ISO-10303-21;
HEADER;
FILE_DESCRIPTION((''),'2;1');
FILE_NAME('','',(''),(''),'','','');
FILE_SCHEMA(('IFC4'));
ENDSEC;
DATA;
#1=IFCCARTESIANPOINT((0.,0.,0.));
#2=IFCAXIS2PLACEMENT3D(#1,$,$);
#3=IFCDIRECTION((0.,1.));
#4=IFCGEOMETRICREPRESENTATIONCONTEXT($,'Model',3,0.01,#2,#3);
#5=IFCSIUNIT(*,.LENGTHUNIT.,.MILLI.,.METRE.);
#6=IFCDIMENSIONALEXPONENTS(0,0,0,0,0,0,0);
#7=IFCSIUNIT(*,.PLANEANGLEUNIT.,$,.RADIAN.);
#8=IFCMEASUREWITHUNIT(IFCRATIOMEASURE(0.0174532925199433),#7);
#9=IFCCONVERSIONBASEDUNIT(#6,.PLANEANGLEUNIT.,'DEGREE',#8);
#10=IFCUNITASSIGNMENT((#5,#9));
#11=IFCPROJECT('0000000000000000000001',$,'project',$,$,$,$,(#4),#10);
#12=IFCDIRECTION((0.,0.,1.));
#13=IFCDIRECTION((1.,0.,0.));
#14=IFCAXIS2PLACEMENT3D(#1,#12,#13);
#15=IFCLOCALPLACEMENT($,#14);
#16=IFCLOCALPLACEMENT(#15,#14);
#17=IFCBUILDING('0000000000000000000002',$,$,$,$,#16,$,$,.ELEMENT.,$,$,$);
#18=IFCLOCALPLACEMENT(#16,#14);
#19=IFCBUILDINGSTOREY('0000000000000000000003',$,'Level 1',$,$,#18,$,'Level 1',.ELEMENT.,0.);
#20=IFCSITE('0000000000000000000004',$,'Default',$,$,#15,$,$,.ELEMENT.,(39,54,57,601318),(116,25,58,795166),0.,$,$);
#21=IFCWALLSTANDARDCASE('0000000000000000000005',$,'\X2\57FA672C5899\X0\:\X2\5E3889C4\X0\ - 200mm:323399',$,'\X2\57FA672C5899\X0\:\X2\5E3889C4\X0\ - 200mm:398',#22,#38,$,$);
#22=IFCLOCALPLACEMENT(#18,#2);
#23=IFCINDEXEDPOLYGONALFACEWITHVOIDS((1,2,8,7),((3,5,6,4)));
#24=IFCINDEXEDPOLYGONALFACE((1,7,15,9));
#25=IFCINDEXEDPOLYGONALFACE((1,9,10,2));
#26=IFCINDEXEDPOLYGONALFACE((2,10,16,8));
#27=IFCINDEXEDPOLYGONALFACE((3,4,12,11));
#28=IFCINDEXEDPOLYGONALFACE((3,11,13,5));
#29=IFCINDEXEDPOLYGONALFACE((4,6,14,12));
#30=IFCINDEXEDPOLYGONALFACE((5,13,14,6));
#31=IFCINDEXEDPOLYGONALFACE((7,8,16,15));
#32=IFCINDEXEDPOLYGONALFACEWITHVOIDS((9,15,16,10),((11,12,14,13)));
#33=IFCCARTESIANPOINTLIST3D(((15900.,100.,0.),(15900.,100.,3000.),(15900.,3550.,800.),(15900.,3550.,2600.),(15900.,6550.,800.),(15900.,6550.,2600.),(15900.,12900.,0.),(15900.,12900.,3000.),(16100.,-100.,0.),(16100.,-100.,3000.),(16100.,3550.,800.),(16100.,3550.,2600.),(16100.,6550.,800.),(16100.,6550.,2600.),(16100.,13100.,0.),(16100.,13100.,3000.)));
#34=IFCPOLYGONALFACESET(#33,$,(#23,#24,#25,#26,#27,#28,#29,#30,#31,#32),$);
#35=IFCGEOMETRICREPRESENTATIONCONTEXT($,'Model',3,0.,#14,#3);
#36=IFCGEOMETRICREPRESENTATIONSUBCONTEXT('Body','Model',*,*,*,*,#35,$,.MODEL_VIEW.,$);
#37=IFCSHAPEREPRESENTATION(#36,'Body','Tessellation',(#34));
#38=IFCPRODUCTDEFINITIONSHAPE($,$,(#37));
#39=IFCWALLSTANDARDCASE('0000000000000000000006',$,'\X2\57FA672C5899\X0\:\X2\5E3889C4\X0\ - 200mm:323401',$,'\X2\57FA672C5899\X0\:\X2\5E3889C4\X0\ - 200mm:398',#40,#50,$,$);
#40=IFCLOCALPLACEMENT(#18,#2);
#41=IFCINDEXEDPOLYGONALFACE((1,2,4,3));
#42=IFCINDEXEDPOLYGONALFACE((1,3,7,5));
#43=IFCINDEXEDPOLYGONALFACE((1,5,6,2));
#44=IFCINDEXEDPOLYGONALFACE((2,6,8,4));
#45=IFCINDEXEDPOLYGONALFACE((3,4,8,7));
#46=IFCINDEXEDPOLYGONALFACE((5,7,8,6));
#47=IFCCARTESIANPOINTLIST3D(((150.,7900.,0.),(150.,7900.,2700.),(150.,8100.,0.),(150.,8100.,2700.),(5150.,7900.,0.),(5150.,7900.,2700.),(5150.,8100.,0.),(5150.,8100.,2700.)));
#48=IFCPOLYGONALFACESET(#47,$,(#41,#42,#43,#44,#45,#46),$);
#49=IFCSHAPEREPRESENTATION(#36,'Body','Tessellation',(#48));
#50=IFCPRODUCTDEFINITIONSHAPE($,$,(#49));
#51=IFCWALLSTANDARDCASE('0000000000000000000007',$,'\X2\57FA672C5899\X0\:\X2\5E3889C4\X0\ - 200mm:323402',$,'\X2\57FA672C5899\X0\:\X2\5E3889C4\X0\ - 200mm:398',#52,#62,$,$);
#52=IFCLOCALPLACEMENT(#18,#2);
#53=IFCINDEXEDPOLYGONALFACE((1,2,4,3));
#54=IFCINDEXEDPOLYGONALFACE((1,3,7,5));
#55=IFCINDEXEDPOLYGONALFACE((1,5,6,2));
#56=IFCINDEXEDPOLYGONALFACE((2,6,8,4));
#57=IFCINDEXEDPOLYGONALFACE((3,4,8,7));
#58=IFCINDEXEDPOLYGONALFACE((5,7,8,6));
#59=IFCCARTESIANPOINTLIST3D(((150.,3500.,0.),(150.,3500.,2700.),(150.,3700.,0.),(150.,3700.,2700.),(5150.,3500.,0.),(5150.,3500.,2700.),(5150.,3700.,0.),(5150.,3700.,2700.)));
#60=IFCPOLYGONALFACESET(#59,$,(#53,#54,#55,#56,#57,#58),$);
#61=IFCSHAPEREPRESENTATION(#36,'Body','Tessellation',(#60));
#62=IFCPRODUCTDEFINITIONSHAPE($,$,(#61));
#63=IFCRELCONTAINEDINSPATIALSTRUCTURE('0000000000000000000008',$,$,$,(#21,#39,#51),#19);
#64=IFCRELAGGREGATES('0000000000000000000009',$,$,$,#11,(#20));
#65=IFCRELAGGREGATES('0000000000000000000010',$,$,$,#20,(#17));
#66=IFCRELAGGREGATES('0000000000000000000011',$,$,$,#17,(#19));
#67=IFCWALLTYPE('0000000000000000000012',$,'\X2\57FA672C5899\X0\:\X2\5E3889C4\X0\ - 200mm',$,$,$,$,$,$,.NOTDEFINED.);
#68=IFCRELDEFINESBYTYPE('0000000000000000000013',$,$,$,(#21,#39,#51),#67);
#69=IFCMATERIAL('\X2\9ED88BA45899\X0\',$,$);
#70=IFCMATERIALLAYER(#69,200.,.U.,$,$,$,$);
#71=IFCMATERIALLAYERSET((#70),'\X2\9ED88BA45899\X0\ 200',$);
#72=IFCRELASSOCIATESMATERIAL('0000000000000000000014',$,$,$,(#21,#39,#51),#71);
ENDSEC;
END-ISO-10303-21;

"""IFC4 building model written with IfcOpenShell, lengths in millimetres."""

from ifc_helpers import new_model, entity, si_unit, converted_unit, direction, frame, origin, origin_with_axes, place, context, subcontext, project, spatial, polyline, outline, extrude, clip, halfspace, material, layer, layer_set, layer_usage, type_object, element, save


model = new_model("IFC4")

# Units and contexts
model_context_1 = context("Model", 3, precision=0.01, world=origin(), true_north=direction((0.0, 1.0)))
model_context_2 = context("Model", 3, precision=0.0, world=origin_with_axes(), true_north=direction((0.0, 1.0)))
body_context = subcontext(model_context_2, "Body", "Model", "MODEL_VIEW")
ifc_project = project(units=[si_unit("LENGTHUNIT", "METRE", prefix="MILLI"), converted_unit("PLANEANGLEUNIT", "DEGREE", entity("IfcRatioMeasure", 0.0174532925199433), si_unit("PLANEANGLEUNIT", "RADIAN"), dimensions=[0, 0, 0, 0, 0, 0, 0])], contexts=[model_context_1])

# Site, building, storey
site_placement = place(None, origin_with_axes())
site = spatial("IfcSite", under=ifc_project, at=site_placement, Name="Default", CompositionType="ELEMENT", RefLatitude=(39, 54, 57, 601318), RefLongitude=(116, 25, 58, 795166), RefElevation=0.0)
building_placement = place(site_placement, origin_with_axes())
building = spatial("IfcBuilding", under=site, at=building_placement, CompositionType="ELEMENT")
storey_placement = place(building_placement, origin_with_axes())
storey = spatial("IfcBuildingStorey", under=building, at=storey_placement, Name="Level 1", LongName="Level 1", CompositionType="ELEMENT", Elevation=0.0)

# Shared definitions
ifc_material_1 = material(Name="默认墙")
ifc_layer_1 = layer(ifc_material_1, 200.0, ventilated="UNKNOWN")
ifc_layer_set_1 = layer_set([ifc_layer_1], Name="默认墙 200")
wall_type = type_object("IfcWallType", Name="基本墙:常规 - 200mm", PredefinedType="NOTDEFINED")

# Wall, opening
ifc_layer_usage_1 = layer_usage(ifc_layer_set_1, "AXIS2", "POSITIVE", -100.0)
wall_1_placement = place(storey_placement, frame((16000.0, 13000.0, 0.0), z_axis=(0.0, 0.0, 1.0), x_axis=(0.0, -1.0, 0.0)))
wall_1 = element("IfcWallStandardCase", 1, at=wall_1_placement, inside=storey, type_object=wall_type, material=ifc_layer_usage_1, Name="基本墙:常规 - 200mm:323399", ObjectType="基本墙:常规 - 200mm:398", context=body_context, shape_type="SweptSolid", body=[
    extrude(outline(polyline([(100.0, -100.0), (12900.0, -100.0), (13100.0, 100.0), (-100.0, 100.0), (100.0, -100.0)])), origin_with_axes(), (0.0, 0.0, 1.0), 3000.0),
])
opening_1_placement = place(wall_1_placement, frame((7950.0, 0.0, 800.0), z_axis=(0.0, 0.0, 1.0), x_axis=(1.0, 0.0, 0.0)))
element("IfcOpeningElement", 2, at=opening_1_placement, cuts=wall_1, context=body_context, shape_type="SweptSolid", body=[
    extrude(outline(polyline([(-1500.0, 0.0), (-1500.0, -1800.0), (1500.0, -1800.0), (1500.0, 0.0), (-1500.0, 0.0)])), frame((0.0, -100.0, 0.0), z_axis=(0.0, 1.0, 0.0), x_axis=(1.0, 0.0, 0.0)), (0.0, 0.0, 1.0), 200.0),
])

# Walls
ifc_layer_usage_2 = layer_usage(ifc_layer_set_1, "AXIS2", "POSITIVE", -100.0)
wall_2_placement = place(storey_placement, frame((150.0, 8000.0, 0.0), z_axis=(0.0, 0.0, 1.0), x_axis=(1.0, 0.0, 0.0)))
element("IfcWallStandardCase", 3, at=wall_2_placement, inside=storey, type_object=wall_type, material=ifc_layer_usage_2, Name="基本墙:常规 - 200mm:323401", ObjectType="基本墙:常规 - 200mm:398", context=body_context, shape_type="Clipping", body=[
    clip(extrude(outline(polyline([(0.0, -100.0), (5000.0, -100.0), (5000.0, 100.0), (0.0, 100.0), (0.0, -100.0)])), origin_with_axes(), (0.0, 0.0, 1.0), 2700.0), halfspace(frame((0.0, 0.0, 2700.0), z_axis=(0.0, 0.0, -1.0), x_axis=(0.0, 1.0, 0.0)), True)),
])
ifc_layer_usage_3 = layer_usage(ifc_layer_set_1, "AXIS2", "POSITIVE", -100.0)
wall_3_placement = place(storey_placement, frame((150.0, 3600.0, 0.0), z_axis=(0.0, 0.0, 1.0), x_axis=(1.0, 0.0, 0.0)))
element("IfcWallStandardCase", 4, at=wall_3_placement, inside=storey, type_object=wall_type, material=ifc_layer_usage_3, Name="基本墙:常规 - 200mm:323402", ObjectType="基本墙:常规 - 200mm:398", context=body_context, shape_type="Clipping", body=[
    clip(extrude(outline(polyline([(0.0, -100.0), (5000.0, -100.0), (5000.0, 100.0), (0.0, 100.0), (0.0, -100.0)])), origin_with_axes(), (0.0, 0.0, 1.0), 2700.0), halfspace(frame((0.0, 0.0, 2700.0), z_axis=(0.0, 0.0, -1.0), x_axis=(0.0, 1.0, 0.0)), True)),
])

save(model, "model.ifc")
